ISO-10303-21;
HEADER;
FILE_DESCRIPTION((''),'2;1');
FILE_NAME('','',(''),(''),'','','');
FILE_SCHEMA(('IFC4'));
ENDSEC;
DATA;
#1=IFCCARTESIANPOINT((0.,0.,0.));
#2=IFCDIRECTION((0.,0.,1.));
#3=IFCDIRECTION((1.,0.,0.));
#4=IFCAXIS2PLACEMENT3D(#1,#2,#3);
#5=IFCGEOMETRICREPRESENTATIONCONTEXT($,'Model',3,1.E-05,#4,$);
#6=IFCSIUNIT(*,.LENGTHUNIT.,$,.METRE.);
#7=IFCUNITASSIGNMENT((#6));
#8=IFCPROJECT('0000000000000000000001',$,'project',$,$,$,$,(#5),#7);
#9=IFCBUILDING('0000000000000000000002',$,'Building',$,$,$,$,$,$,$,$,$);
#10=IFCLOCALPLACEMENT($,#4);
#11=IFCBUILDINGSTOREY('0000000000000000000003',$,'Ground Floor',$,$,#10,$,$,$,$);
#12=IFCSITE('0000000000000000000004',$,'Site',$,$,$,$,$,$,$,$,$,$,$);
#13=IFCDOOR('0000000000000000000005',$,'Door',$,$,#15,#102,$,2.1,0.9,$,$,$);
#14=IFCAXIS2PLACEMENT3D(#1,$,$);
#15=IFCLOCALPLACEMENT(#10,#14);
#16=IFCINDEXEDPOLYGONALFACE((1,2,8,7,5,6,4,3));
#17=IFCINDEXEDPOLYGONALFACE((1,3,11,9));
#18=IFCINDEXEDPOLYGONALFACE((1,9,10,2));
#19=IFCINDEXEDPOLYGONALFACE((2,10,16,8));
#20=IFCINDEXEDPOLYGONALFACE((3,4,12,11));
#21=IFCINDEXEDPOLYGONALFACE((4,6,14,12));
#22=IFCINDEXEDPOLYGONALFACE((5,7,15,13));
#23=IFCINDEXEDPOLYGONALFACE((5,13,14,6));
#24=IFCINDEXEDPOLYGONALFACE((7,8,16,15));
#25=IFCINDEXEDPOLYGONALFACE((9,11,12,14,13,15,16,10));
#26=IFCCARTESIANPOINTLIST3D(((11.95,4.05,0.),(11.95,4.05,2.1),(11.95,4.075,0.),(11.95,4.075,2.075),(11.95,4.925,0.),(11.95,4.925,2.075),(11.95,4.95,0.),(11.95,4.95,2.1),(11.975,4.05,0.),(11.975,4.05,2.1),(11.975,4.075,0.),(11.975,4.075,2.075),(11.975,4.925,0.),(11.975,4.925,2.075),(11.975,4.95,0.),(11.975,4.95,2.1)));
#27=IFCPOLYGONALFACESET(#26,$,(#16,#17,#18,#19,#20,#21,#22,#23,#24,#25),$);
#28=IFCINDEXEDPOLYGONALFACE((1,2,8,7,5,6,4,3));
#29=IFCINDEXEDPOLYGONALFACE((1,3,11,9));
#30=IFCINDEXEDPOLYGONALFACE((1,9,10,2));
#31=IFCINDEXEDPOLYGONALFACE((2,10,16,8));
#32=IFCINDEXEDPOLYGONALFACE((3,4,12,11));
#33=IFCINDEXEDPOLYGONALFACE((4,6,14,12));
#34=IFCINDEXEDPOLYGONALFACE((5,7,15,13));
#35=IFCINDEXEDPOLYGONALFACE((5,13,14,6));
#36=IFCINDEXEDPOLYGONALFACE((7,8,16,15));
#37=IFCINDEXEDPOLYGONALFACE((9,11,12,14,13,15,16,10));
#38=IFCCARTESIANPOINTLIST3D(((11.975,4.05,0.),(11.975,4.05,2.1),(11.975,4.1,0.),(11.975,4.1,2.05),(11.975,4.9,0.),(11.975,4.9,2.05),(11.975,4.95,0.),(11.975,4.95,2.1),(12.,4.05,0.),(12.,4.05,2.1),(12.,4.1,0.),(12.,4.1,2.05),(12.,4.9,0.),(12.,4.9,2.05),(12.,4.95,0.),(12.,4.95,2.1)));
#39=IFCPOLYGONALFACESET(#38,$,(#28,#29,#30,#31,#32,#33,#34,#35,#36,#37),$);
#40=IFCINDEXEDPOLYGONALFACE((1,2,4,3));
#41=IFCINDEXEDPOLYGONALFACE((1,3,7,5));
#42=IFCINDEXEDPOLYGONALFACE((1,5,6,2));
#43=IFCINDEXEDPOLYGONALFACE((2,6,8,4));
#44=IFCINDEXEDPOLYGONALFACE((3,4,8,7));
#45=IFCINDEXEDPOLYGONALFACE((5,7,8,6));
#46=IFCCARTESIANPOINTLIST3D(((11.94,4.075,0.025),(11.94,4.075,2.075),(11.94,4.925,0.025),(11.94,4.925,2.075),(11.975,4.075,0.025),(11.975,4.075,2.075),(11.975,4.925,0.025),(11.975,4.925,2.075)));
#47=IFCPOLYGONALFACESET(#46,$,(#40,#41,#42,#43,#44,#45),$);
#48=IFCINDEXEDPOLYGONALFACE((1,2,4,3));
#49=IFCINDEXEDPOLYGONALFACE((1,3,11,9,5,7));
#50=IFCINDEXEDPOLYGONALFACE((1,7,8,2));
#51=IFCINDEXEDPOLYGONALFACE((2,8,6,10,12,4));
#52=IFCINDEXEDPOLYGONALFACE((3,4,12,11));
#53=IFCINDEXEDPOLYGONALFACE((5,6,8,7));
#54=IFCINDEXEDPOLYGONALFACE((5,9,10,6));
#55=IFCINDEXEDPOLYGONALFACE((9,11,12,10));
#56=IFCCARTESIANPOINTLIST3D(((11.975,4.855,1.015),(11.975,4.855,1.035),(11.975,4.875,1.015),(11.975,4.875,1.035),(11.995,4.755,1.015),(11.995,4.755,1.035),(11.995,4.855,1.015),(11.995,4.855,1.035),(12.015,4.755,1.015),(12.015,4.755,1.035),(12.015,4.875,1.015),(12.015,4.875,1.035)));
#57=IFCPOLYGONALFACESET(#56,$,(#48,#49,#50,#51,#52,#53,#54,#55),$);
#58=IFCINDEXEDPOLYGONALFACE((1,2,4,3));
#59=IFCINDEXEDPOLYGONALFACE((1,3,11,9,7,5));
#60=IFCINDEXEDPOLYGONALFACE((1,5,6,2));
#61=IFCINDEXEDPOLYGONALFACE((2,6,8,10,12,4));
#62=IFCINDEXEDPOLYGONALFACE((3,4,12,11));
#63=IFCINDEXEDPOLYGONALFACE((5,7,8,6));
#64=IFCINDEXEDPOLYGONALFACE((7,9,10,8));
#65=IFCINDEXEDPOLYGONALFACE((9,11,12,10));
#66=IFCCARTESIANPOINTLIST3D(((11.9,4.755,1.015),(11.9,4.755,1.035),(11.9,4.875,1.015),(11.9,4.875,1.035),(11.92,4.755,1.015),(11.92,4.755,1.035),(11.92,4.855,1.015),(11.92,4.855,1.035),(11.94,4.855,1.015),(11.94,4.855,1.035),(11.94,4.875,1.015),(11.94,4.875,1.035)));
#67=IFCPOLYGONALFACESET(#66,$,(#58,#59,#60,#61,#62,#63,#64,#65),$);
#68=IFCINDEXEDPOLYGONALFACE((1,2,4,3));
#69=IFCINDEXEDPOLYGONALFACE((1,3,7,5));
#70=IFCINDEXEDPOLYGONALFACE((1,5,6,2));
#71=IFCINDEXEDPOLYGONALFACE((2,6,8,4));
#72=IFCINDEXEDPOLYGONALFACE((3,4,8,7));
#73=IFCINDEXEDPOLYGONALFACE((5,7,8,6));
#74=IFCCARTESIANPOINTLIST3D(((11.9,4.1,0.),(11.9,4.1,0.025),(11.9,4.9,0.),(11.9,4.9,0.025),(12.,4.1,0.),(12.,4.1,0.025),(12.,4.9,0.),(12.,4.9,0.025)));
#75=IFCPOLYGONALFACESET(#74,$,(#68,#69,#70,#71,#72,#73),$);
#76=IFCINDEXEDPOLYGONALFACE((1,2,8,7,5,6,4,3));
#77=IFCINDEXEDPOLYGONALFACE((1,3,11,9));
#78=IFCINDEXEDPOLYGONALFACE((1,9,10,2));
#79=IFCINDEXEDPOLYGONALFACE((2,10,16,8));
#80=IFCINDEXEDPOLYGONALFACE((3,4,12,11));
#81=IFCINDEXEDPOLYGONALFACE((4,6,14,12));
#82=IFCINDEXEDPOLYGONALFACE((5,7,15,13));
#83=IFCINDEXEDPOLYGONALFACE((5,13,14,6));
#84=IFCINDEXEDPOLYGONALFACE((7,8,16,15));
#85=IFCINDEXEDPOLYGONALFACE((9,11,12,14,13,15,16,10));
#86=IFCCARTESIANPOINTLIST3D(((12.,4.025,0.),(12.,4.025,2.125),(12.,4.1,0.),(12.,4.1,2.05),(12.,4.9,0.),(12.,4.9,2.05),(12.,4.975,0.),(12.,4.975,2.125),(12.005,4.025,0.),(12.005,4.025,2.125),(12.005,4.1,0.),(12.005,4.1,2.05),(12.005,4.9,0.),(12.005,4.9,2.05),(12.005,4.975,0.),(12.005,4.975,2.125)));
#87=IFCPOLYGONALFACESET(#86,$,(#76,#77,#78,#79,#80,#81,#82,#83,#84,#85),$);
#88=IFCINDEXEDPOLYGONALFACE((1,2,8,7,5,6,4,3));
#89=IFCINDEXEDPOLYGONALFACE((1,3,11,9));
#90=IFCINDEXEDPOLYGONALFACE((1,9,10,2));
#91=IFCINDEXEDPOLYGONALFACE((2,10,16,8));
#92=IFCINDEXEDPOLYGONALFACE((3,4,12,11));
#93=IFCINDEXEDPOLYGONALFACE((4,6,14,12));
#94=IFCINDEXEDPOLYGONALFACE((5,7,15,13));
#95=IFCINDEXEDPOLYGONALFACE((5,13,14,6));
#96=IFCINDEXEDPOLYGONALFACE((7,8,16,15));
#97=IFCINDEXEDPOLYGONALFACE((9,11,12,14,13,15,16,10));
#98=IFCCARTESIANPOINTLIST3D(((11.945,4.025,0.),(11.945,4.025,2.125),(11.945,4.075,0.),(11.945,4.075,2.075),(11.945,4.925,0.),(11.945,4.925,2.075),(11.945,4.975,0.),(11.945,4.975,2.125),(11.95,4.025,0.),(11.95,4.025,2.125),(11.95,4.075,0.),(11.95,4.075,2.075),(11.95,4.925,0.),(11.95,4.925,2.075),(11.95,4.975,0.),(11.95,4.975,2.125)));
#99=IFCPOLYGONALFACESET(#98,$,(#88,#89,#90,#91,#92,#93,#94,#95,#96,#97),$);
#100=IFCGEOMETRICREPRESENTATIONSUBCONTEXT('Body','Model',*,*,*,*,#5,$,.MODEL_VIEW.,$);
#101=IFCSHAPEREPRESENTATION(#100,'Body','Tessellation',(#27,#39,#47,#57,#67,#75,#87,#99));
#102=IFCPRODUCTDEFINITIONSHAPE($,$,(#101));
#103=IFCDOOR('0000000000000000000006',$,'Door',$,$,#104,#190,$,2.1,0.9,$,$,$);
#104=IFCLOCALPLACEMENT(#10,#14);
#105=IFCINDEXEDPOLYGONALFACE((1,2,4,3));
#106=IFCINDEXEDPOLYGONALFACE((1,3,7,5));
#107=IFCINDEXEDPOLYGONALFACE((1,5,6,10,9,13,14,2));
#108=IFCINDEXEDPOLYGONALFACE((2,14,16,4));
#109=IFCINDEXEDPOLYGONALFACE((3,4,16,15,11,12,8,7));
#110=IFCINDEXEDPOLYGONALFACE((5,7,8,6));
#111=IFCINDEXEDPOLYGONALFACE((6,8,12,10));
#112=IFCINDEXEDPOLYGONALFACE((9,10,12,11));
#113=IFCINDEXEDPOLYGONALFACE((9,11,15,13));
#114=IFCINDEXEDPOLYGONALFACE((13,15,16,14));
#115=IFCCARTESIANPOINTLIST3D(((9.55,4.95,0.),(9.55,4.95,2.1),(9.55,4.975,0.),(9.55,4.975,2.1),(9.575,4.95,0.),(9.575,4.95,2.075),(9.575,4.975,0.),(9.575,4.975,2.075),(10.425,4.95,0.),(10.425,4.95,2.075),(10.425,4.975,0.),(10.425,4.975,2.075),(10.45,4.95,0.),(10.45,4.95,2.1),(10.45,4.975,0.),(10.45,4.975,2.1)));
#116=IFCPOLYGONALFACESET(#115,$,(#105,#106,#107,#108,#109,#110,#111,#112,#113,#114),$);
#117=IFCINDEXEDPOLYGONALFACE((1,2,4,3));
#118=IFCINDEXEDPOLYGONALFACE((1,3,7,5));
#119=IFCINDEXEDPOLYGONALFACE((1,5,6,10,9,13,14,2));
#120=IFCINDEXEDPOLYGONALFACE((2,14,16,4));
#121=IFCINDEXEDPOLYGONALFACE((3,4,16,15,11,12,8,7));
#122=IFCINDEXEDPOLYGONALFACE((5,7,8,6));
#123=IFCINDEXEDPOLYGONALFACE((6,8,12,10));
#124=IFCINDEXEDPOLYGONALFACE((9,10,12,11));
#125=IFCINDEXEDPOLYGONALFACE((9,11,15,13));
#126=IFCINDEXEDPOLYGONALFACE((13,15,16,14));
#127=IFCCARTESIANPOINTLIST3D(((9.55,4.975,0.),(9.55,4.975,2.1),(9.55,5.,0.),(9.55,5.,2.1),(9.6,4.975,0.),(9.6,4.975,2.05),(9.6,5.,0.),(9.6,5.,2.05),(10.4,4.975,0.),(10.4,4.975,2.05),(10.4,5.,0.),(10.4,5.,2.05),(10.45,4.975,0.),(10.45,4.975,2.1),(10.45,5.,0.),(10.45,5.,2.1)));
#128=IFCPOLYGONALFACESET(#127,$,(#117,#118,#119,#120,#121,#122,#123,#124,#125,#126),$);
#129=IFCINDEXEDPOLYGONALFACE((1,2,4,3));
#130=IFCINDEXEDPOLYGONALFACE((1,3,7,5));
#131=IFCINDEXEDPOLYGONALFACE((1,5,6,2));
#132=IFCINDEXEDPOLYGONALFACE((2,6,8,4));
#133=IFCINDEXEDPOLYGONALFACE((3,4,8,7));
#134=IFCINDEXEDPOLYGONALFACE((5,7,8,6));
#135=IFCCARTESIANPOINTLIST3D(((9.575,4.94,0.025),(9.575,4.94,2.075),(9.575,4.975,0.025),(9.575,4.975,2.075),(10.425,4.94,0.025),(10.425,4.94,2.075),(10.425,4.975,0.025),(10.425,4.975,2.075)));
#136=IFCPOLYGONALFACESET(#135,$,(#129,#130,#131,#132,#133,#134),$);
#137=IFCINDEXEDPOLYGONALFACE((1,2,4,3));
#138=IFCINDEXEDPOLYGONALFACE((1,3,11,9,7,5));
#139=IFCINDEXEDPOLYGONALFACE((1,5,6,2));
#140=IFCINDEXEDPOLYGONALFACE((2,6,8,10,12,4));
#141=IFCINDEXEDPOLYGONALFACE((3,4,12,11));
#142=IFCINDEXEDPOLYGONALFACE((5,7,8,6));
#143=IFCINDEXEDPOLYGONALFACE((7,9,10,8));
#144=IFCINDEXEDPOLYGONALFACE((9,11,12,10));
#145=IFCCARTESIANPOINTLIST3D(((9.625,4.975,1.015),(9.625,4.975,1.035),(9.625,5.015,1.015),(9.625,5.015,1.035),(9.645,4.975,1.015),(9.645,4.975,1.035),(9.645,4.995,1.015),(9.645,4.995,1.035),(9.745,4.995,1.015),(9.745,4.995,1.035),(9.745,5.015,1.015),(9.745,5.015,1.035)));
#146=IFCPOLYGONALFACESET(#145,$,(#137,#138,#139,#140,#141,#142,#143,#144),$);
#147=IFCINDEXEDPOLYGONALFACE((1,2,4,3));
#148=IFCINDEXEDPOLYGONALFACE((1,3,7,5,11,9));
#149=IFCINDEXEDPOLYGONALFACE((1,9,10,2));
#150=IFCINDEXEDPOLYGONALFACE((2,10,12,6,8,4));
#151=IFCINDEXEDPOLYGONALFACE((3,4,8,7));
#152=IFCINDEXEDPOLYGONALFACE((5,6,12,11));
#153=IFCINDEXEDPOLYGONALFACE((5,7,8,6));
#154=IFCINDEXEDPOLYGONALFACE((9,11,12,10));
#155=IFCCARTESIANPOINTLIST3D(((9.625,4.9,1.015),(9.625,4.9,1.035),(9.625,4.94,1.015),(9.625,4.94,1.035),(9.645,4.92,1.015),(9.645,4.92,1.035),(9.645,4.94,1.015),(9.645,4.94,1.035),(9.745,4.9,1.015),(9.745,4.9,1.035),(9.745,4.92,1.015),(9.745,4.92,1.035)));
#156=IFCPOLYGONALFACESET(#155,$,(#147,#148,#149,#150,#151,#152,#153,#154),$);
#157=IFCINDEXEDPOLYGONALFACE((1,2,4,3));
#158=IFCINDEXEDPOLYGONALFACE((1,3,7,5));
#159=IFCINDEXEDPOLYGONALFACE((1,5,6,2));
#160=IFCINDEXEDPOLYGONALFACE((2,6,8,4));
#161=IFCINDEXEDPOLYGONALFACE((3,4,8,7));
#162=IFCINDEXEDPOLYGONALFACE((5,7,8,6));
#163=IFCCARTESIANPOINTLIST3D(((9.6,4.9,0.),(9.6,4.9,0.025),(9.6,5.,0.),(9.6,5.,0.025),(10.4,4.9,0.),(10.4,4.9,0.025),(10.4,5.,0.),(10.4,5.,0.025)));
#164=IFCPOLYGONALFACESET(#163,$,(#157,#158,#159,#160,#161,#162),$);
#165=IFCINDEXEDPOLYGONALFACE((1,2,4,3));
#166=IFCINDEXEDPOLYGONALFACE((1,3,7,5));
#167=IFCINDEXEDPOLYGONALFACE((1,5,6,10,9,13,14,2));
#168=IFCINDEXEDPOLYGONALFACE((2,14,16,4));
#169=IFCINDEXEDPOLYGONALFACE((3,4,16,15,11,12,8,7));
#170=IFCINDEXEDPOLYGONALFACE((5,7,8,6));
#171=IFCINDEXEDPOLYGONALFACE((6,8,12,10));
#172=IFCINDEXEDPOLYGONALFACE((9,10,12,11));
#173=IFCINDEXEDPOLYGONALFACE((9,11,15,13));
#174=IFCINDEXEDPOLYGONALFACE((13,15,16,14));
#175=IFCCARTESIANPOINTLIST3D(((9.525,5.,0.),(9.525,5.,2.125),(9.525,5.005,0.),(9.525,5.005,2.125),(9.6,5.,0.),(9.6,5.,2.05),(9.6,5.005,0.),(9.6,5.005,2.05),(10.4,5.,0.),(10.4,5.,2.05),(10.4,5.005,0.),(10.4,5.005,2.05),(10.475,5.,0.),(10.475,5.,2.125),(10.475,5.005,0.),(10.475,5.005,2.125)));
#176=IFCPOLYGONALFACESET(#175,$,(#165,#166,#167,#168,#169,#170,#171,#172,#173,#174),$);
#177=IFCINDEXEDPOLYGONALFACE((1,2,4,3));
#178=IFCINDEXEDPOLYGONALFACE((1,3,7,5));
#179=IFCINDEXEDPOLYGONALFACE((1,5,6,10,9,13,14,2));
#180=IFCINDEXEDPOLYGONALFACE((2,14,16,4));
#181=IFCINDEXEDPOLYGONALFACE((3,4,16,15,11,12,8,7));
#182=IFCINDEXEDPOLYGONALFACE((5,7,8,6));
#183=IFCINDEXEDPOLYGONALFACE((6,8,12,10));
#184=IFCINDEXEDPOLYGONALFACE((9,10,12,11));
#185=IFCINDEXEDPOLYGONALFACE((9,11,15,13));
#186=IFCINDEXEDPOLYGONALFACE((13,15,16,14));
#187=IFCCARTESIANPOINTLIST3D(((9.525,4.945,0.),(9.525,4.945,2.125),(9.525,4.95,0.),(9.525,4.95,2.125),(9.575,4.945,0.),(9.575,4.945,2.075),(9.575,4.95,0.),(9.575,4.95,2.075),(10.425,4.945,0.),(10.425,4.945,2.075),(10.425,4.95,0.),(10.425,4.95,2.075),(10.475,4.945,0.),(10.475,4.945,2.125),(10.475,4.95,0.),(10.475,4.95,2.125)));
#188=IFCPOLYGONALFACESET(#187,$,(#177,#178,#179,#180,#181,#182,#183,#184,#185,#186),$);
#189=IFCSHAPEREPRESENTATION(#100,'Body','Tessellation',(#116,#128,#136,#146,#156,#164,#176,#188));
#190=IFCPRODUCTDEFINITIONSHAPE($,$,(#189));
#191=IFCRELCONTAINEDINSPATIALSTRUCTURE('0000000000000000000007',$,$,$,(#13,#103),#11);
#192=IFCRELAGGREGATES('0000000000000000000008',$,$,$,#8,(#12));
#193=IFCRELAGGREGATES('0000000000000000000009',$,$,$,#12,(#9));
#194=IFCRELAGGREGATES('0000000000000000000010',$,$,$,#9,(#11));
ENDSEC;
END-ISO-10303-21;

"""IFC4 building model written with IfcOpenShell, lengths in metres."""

from ifc_helpers import new_model, si_unit, frame, origin_with_axes, place, context, subcontext, project, spatial, line, indexed_curve, outline, extrude, element, save


model = new_model("IFC4")

# Units and contexts
model_context = context("Model", 3, precision=1e-05, world=origin_with_axes())
body_context = subcontext(model_context, "Body", "Model", "MODEL_VIEW")
ifc_project = project(units=[si_unit("LENGTHUNIT", "METRE")], contexts=[model_context])

# Site, building, storey
site = spatial("IfcSite", under=ifc_project, Name="Site")
building = spatial("IfcBuilding", under=site, Name="Building")
storey_placement = place(None, origin_with_axes())
storey = spatial("IfcBuildingStorey", under=building, at=storey_placement, Name="Ground Floor")

# Doors
door_1_placement = place(storey_placement, frame((12.0, 4.05, 0.0), z_axis=(0.0, 0.0, 1.0), x_axis=(0.0, 1.0, 0.0)))
element("IfcDoor", 1, at=door_1_placement, inside=storey, Name="Door", OverallHeight=2.1, OverallWidth=0.9, context=body_context, shape_type="SweptSolid", body=[
    extrude(outline(indexed_curve([(0.0, 0.0), (0.0, 2.1), (0.9, 2.1), (0.9, 0.0), (0.875, 0.0), (0.875, 2.075), (0.025, 2.075), (0.025, 0.0)], segments=[line(1, 2, 3, 4, 5, 6, 7, 8, 1)])), frame((0.0, 0.025, 0.0), z_axis=(0.0, -1.0, 0.0), x_axis=(1.0, 0.0, 0.0)), (0.0, 0.0, -1.0), 0.025),
    extrude(outline(indexed_curve([(0.0, 0.0), (0.0, 2.1), (0.9, 2.1), (0.9, 0.0), (0.85, 0.0), (0.85, 2.05), (0.05, 2.05), (0.05, 0.0)], segments=[line(1, 2, 3, 4, 5, 6, 7, 8, 1)])), frame((0.0, 0.0, 0.0), z_axis=(0.0, -1.0, 0.0), x_axis=(1.0, 0.0, 0.0)), (0.0, 0.0, -1.0), 0.025),
    extrude(outline(indexed_curve([(0.0, 0.0), (0.85, 0.0), (0.85, 0.035), (0.0, 0.035)], segments=[line(1, 2, 3, 4, 1)])), frame((0.025, 0.025, 0.025), z_axis=(0.0, 0.0, 1.0), x_axis=(1.0, 0.0, 0.0)), (0.0, 0.0, 1.0), 2.05),
    extrude(outline(indexed_curve([(0.0, 0.0), (0.0, -0.04), (-0.12, -0.04), (-0.12, -0.02), (-0.02, -0.02), (-0.02, 0.0)], segments=[line(1, 2, 3, 4, 5, 6, 1)])), frame((0.825, 0.025, 1.015), z_axis=(0.0, 0.0, 1.0), x_axis=(1.0, 0.0, 0.0)), (0.0, 0.0, 1.0), 0.02),
    extrude(outline(indexed_curve([(0.0, 0.0), (0.0, 0.04), (-0.12, 0.04), (-0.12, 0.02), (-0.02, 0.02), (-0.02, 0.0)], segments=[line(1, 2, 3, 4, 5, 6, 1)])), frame((0.825, 0.06, 1.015), z_axis=(0.0, 0.0, 1.0), x_axis=(1.0, 0.0, 0.0)), (0.0, 0.0, 1.0), 0.02),
    extrude(outline(indexed_curve([(0.0, 0.0), (0.8, 0.0), (0.8, 0.1), (0.0, 0.1)], segments=[line(1, 2, 3, 4, 1)])), frame((0.05, 0.0, 0.0), z_axis=(0.0, 0.0, 1.0), x_axis=(1.0, 0.0, 0.0)), (0.0, 0.0, 1.0), 0.025),
    extrude(outline(indexed_curve([(0.0, 0.0), (0.0, 2.125), (0.95, 2.125), (0.95, 0.0), (0.875, 0.0), (0.875, 2.05), (0.075, 2.05), (0.075, 0.0)], segments=[line(1, 2, 3, 4, 5, 6, 7, 8, 1)])), frame((-0.025, -0.005, 0.0), z_axis=(0.0, -1.0, 0.0), x_axis=(1.0, 0.0, 0.0)), (0.0, 0.0, -1.0), 0.005),
    extrude(outline(indexed_curve([(0.0, 0.0), (0.0, 2.125), (0.95, 2.125), (0.95, 0.0), (0.9, 0.0), (0.9, 2.075), (0.05, 2.075), (0.05, 0.0)], segments=[line(1, 2, 3, 4, 5, 6, 7, 8, 1)])), frame((-0.025, 0.05, 0.0), z_axis=(0.0, -1.0, 0.0), x_axis=(1.0, 0.0, 0.0)), (0.0, 0.0, -1.0), 0.005),
])
door_2_placement = place(storey_placement, frame((10.45, 5.0, 0.0), z_axis=(0.0, 0.0, 1.0), x_axis=(-1.0, 0.0, 0.0)))
element("IfcDoor", 2, at=door_2_placement, inside=storey, Name="Door", OverallHeight=2.1, OverallWidth=0.9, context=body_context, shape_type="SweptSolid", body=[
    extrude(outline(indexed_curve([(0.0, 0.0), (0.0, 2.1), (0.9, 2.1), (0.9, 0.0), (0.875, 0.0), (0.875, 2.075), (0.025, 2.075), (0.025, 0.0)], segments=[line(1, 2, 3, 4, 5, 6, 7, 8, 1)])), frame((0.0, 0.025, 0.0), z_axis=(0.0, -1.0, 0.0), x_axis=(1.0, 0.0, 0.0)), (0.0, 0.0, -1.0), 0.025),
    extrude(outline(indexed_curve([(0.0, 0.0), (0.0, 2.1), (0.9, 2.1), (0.9, 0.0), (0.85, 0.0), (0.85, 2.05), (0.05, 2.05), (0.05, 0.0)], segments=[line(1, 2, 3, 4, 5, 6, 7, 8, 1)])), frame((0.0, 0.0, 0.0), z_axis=(0.0, -1.0, 0.0), x_axis=(1.0, 0.0, 0.0)), (0.0, 0.0, -1.0), 0.025),
    extrude(outline(indexed_curve([(0.0, 0.0), (0.85, 0.0), (0.85, 0.035), (0.0, 0.035)], segments=[line(1, 2, 3, 4, 1)])), frame((0.025, 0.025, 0.025), z_axis=(0.0, 0.0, 1.0), x_axis=(1.0, 0.0, 0.0)), (0.0, 0.0, 1.0), 2.05),
    extrude(outline(indexed_curve([(0.0, 0.0), (0.0, -0.04), (-0.12, -0.04), (-0.12, -0.02), (-0.02, -0.02), (-0.02, 0.0)], segments=[line(1, 2, 3, 4, 5, 6, 1)])), frame((0.825, 0.025, 1.015), z_axis=(0.0, 0.0, 1.0), x_axis=(1.0, 0.0, 0.0)), (0.0, 0.0, 1.0), 0.02),
    extrude(outline(indexed_curve([(0.0, 0.0), (0.0, 0.04), (-0.12, 0.04), (-0.12, 0.02), (-0.02, 0.02), (-0.02, 0.0)], segments=[line(1, 2, 3, 4, 5, 6, 1)])), frame((0.825, 0.06, 1.015), z_axis=(0.0, 0.0, 1.0), x_axis=(1.0, 0.0, 0.0)), (0.0, 0.0, 1.0), 0.02),
    extrude(outline(indexed_curve([(0.0, 0.0), (0.8, 0.0), (0.8, 0.1), (0.0, 0.1)], segments=[line(1, 2, 3, 4, 1)])), frame((0.05, 0.0, 0.0), z_axis=(0.0, 0.0, 1.0), x_axis=(1.0, 0.0, 0.0)), (0.0, 0.0, 1.0), 0.025),
    extrude(outline(indexed_curve([(0.0, 0.0), (0.0, 2.125), (0.95, 2.125), (0.95, 0.0), (0.875, 0.0), (0.875, 2.05), (0.075, 2.05), (0.075, 0.0)], segments=[line(1, 2, 3, 4, 5, 6, 7, 8, 1)])), frame((-0.025, -0.005, 0.0), z_axis=(0.0, -1.0, 0.0), x_axis=(1.0, 0.0, 0.0)), (0.0, 0.0, -1.0), 0.005),
    extrude(outline(indexed_curve([(0.0, 0.0), (0.0, 2.125), (0.95, 2.125), (0.95, 0.0), (0.9, 0.0), (0.9, 2.075), (0.05, 2.075), (0.05, 0.0)], segments=[line(1, 2, 3, 4, 5, 6, 7, 8, 1)])), frame((-0.025, 0.05, 0.0), z_axis=(0.0, -1.0, 0.0), x_axis=(1.0, 0.0, 0.0)), (0.0, 0.0, -1.0), 0.005),
])

save(model, "model.ifc")
